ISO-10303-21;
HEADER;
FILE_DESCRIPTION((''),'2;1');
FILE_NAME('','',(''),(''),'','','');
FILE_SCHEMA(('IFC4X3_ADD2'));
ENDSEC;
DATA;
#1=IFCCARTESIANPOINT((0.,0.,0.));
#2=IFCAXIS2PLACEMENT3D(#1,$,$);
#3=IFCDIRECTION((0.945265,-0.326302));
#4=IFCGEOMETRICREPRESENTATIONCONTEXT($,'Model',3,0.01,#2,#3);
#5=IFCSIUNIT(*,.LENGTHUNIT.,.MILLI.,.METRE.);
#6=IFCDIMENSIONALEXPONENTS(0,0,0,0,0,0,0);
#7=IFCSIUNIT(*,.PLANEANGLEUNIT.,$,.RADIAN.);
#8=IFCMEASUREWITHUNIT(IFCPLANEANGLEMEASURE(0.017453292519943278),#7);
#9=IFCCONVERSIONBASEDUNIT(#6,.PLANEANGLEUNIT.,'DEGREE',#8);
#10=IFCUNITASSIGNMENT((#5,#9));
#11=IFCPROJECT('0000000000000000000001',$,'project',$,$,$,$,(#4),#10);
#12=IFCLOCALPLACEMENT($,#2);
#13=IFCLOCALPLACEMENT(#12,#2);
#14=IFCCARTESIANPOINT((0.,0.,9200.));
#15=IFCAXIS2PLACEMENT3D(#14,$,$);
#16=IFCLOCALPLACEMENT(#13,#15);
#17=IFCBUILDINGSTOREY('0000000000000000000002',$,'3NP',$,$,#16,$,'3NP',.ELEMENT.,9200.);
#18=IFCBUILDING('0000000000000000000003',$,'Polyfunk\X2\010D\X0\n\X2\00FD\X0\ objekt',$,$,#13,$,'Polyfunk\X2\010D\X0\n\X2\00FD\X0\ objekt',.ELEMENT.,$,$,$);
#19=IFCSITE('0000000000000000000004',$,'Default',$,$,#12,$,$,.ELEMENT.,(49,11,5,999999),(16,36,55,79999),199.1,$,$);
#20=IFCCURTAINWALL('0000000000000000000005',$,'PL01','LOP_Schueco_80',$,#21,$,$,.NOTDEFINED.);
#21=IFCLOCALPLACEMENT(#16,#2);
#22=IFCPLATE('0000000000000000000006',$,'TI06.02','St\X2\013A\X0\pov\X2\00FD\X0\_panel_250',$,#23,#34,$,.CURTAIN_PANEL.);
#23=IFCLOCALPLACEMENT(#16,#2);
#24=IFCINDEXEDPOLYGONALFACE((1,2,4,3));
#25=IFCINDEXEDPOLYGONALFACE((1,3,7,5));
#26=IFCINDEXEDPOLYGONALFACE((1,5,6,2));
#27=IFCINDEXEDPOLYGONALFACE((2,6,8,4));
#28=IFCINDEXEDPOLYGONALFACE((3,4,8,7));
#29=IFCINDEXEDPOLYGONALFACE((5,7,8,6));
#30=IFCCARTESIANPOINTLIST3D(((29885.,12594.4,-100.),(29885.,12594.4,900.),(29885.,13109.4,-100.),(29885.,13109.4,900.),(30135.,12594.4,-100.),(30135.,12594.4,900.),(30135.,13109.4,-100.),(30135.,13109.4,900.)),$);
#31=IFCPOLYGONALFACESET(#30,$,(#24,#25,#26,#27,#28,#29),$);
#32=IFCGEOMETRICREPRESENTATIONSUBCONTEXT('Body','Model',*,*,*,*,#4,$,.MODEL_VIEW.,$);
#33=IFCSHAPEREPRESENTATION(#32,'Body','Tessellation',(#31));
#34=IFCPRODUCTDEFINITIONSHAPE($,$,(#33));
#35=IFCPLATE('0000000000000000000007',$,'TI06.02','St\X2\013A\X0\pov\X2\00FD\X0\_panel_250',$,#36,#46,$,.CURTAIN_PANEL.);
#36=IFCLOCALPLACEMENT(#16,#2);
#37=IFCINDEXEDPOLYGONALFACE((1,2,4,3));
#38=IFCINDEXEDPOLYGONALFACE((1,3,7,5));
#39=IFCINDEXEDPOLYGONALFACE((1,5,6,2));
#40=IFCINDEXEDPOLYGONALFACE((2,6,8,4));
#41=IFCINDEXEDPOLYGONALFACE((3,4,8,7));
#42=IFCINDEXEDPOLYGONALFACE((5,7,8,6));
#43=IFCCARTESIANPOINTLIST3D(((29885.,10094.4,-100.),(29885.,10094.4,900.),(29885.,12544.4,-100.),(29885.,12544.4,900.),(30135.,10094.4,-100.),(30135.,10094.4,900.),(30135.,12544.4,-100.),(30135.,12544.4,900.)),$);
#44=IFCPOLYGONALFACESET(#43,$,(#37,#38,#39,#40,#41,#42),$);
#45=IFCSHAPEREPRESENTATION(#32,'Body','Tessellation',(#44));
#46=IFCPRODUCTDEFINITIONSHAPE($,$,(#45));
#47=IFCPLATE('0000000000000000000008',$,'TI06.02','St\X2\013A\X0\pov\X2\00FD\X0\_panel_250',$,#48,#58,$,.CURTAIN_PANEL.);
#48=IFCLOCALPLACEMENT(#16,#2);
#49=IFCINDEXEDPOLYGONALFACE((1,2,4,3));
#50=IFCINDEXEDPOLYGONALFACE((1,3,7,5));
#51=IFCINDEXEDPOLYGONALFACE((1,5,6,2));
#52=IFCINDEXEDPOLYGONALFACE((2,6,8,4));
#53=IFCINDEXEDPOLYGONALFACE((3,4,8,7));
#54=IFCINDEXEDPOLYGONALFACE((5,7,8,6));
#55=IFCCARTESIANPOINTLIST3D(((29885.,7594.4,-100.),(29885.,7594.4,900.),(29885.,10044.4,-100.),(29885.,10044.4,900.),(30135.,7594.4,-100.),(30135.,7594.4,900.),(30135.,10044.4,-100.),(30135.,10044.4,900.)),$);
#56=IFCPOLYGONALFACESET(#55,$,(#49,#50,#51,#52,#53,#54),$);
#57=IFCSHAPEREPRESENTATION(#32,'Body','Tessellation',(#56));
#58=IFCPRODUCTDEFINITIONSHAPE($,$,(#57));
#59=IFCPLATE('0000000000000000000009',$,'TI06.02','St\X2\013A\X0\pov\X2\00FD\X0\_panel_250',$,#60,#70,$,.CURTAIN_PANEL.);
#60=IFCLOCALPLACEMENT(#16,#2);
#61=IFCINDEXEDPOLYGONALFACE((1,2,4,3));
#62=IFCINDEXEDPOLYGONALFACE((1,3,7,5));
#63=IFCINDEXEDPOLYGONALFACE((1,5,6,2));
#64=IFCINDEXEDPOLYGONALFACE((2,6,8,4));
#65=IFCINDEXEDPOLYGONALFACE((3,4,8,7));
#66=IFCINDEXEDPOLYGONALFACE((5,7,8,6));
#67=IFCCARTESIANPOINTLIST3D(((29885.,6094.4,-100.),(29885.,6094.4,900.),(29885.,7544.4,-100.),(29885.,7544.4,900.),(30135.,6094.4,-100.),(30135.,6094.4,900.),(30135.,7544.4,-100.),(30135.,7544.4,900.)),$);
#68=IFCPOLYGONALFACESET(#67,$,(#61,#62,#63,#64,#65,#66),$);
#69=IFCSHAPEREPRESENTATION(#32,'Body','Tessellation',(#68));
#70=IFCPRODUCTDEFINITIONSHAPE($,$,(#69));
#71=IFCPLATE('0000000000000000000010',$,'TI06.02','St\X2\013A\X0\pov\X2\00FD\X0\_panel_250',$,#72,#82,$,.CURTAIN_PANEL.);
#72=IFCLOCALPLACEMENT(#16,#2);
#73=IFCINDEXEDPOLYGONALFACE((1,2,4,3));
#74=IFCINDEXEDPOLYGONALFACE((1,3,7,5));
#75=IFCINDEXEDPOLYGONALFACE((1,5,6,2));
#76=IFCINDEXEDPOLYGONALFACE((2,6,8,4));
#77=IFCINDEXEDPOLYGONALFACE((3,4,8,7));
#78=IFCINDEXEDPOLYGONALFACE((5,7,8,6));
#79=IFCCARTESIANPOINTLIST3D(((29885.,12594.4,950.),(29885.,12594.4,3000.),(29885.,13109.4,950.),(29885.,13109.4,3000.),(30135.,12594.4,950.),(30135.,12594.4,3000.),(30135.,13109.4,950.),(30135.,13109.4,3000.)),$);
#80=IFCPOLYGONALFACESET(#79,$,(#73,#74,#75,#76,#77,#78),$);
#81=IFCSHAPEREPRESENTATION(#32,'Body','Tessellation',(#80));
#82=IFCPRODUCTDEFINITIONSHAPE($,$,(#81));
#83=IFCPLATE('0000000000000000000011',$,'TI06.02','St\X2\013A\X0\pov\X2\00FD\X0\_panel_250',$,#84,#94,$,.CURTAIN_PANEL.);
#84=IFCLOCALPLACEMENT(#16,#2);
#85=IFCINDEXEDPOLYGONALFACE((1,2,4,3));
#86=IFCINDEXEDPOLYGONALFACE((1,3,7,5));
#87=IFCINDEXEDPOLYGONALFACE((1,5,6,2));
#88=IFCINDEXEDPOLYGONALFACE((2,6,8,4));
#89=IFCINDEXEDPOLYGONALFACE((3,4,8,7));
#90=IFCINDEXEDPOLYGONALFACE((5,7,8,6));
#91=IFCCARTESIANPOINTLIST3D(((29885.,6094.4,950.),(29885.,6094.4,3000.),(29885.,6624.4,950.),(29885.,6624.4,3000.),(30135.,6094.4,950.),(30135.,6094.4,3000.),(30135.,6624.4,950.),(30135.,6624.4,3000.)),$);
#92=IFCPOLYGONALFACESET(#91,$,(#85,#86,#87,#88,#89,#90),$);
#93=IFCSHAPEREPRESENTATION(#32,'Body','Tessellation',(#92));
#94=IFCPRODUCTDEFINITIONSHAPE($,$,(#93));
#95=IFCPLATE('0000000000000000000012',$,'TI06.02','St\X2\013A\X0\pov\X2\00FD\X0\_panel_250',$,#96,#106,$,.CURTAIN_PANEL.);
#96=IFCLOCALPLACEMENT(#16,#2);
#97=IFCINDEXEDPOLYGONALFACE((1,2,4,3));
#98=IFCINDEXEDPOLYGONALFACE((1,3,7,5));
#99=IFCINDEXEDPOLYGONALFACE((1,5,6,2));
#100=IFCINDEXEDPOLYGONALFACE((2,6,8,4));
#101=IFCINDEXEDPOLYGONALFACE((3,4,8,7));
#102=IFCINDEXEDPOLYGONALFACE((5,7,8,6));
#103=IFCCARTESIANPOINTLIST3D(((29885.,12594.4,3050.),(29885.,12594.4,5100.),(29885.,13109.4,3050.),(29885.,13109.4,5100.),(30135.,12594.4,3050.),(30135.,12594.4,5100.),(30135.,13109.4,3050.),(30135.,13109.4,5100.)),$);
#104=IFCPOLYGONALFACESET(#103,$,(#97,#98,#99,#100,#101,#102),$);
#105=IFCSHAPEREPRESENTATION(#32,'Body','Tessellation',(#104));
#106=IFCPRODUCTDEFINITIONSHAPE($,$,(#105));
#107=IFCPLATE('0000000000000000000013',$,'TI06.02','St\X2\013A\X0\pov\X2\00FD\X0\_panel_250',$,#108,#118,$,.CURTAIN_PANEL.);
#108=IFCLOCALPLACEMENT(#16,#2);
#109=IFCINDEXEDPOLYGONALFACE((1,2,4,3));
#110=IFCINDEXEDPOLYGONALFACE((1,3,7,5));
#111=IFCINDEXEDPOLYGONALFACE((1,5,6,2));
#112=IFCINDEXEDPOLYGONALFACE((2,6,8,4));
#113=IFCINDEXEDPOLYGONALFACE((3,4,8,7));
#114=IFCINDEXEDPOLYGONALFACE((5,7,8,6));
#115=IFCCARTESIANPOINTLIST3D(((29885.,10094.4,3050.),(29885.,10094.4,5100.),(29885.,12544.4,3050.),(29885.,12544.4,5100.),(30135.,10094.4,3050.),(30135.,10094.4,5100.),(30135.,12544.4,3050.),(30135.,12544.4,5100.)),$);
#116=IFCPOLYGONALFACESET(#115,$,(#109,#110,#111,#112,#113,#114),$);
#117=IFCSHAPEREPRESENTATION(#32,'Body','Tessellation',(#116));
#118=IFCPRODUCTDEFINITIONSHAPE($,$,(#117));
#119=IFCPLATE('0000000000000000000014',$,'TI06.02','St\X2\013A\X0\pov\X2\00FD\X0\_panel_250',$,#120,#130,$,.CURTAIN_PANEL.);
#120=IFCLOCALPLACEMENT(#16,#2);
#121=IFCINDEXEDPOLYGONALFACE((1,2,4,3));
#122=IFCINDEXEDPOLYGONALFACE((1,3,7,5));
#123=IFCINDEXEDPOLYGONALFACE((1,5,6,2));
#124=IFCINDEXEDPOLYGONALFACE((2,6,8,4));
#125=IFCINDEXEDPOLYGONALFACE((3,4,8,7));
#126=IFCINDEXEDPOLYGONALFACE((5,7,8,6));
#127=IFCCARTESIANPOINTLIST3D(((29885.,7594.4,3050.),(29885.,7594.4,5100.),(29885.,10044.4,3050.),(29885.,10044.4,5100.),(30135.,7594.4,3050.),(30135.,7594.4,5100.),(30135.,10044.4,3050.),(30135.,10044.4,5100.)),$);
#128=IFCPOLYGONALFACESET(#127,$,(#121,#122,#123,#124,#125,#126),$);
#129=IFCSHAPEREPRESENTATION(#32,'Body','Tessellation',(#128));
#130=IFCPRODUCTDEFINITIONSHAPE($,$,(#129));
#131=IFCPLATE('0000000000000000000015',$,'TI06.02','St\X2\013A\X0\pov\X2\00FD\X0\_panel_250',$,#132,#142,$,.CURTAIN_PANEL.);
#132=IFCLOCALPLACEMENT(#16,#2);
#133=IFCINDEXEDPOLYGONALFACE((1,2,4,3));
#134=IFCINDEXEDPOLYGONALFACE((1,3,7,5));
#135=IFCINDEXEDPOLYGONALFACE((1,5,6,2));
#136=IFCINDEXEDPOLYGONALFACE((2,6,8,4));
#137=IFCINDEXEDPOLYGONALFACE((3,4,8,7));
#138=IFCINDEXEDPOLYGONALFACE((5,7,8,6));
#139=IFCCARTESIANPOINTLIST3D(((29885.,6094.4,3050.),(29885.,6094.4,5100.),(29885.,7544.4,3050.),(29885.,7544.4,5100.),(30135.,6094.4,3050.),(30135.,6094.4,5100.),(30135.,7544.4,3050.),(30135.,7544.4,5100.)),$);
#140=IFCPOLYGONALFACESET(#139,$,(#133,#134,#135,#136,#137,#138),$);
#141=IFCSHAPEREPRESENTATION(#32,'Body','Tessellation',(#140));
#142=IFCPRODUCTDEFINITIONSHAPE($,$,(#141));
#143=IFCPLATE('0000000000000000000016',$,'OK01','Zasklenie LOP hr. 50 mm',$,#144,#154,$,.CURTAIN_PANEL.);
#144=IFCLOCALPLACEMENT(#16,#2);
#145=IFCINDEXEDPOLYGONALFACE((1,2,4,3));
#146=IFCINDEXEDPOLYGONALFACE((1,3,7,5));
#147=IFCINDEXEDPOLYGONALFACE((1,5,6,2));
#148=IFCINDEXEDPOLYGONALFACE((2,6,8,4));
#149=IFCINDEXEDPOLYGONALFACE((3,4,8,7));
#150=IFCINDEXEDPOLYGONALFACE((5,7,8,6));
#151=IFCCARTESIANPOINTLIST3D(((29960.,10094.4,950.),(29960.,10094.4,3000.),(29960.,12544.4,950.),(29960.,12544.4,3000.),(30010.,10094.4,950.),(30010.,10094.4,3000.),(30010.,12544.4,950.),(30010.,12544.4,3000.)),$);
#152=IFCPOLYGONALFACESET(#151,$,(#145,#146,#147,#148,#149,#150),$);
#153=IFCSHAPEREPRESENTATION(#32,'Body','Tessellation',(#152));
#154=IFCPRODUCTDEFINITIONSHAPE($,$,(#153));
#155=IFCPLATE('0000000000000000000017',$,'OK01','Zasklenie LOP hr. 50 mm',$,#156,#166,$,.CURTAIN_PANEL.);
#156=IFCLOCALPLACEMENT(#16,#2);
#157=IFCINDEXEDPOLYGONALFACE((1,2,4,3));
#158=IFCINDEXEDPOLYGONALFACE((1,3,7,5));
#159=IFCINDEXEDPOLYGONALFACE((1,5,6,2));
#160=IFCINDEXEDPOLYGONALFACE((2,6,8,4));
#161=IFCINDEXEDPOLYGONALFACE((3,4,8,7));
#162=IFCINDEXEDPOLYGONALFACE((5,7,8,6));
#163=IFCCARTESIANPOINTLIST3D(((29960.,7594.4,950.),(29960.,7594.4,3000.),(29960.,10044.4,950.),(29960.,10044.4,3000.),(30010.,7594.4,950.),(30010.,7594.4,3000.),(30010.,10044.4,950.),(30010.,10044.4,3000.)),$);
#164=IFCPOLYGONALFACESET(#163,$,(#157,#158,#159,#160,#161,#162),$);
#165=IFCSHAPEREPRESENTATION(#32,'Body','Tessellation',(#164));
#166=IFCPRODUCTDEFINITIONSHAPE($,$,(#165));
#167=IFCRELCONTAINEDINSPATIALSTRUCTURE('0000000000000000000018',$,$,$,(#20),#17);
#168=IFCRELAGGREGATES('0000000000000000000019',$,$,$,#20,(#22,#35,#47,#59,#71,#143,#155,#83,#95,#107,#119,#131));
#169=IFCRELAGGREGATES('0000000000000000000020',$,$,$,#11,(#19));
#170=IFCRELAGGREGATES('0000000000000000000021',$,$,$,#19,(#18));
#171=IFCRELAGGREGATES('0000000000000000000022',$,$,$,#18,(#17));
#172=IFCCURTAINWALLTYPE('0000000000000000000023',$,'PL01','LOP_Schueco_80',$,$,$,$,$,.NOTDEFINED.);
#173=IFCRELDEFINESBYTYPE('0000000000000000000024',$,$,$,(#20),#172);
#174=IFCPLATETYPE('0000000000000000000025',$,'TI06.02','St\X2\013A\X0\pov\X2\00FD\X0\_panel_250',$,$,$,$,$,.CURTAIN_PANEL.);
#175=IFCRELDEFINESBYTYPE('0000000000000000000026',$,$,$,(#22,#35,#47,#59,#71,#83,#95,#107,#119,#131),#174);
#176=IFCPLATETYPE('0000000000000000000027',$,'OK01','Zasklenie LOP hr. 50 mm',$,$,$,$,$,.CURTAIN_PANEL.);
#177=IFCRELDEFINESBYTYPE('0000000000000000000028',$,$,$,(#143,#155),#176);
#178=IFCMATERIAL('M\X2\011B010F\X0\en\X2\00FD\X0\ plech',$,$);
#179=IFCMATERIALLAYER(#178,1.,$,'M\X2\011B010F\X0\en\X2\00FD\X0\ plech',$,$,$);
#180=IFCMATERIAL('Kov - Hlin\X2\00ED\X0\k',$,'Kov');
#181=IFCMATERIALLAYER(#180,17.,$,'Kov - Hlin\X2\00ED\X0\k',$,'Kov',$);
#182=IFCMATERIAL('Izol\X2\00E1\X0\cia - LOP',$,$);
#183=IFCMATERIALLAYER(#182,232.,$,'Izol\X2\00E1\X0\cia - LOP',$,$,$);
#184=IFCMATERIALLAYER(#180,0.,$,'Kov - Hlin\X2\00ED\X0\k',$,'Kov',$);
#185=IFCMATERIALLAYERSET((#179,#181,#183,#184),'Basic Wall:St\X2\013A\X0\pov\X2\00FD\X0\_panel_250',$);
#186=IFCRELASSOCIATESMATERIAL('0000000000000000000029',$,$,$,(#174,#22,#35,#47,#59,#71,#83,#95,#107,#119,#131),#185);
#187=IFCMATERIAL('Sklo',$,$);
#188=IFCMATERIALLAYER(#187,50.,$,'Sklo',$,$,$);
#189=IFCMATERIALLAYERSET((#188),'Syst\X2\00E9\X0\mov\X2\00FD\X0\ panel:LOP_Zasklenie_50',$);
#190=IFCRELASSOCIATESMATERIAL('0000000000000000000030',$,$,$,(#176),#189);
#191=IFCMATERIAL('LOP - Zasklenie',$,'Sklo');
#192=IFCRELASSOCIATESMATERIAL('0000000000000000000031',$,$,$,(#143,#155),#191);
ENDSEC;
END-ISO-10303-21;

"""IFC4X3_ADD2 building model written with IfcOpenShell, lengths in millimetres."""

from ifc_helpers import new_model, entity, si_unit, converted_unit, direction, frame, frame_2d, origin, origin_2d_with_axis, place, context, subcontext, project, spatial, rectangle, extrude, source, transform, mapped, material, layer, layer_set, layer_usage, type_object, element, aggregate, save


model = new_model("IFC4X3_ADD2")

# Units and contexts
model_context = context("Model", 3, precision=0.01, world=origin(), true_north=direction((0.945265, -0.326302)))
body_context = subcontext(model_context, "Body", "Model", "MODEL_VIEW")
ifc_project = project(units=[si_unit("LENGTHUNIT", "METRE", prefix="MILLI"), converted_unit("PLANEANGLEUNIT", "DEGREE", entity("IfcPlaneAngleMeasure", 0.017453292519943278), si_unit("PLANEANGLEUNIT", "RADIAN"), dimensions=[0, 0, 0, 0, 0, 0, 0])], contexts=[model_context])

# Site, building, storey
site_placement = place(None, origin())
site = spatial("IfcSite", under=ifc_project, at=site_placement, Name="Default", CompositionType="ELEMENT", RefLatitude=(49, 11, 5, 999999), RefLongitude=(16, 36, 55, 79999), RefElevation=199.1)
building_placement = place(site_placement, origin())
building = spatial("IfcBuilding", under=site, at=building_placement, Name="Polyfunkčný objekt", LongName="Polyfunkčný objekt", CompositionType="ELEMENT")
storey_placement = place(building_placement, frame((0.0, 0.0, 9200.0)))
storey = spatial("IfcBuildingStorey", under=building, at=storey_placement, Name="3NP", LongName="3NP", CompositionType="ELEMENT", Elevation=9200.0)

# Shared definitions
curtain_wall_type = type_object("IfcCurtainWallType", Name="PL01", Description="LOP_Schueco_80", PredefinedType="NOTDEFINED")

# Curtain wall, plates
curtain_wall_1_placement = place(storey_placement, frame((0.0, 0.0, -9200.0)))
curtain_wall_1 = element("IfcCurtainWall", 1, at=curtain_wall_1_placement, inside=storey, type_object=curtain_wall_type, Name="PL01", Description="LOP_Schueco_80", PredefinedType="NOTDEFINED")
ifc_material_1 = material(Name="Měďený plech")
ifc_layer_1 = layer(ifc_material_1, 1.0, Name="Měďený plech")
ifc_material_2 = material(Name="Kov - Hliník", Category="Kov")
ifc_layer_2 = layer(ifc_material_2, 17.0, Name="Kov - Hliník", Category="Kov")
ifc_material_3 = material(Name="Izolácia - LOP")
ifc_layer_3 = layer(ifc_material_3, 232.0, Name="Izolácia - LOP")
ifc_layer_4 = layer(ifc_material_2, 0.0, Name="Kov - Hliník", Category="Kov")
ifc_layer_set_1 = layer_set([ifc_layer_1, ifc_layer_2, ifc_layer_3, ifc_layer_4], Name="Basic Wall:Stĺpový_panel_250")
ifc_layer_usage_1 = layer_usage(ifc_layer_set_1, "AXIS2", "POSITIVE", -125.0)
plate_type_1 = type_object("IfcPlateType", Name="TI06.02", Description="Stĺpový_panel_250", PredefinedType="CURTAIN_PANEL", material=ifc_layer_set_1)
plate_1_placement = place(storey_placement, frame((30010.0, 13109.4, -100.0), z_axis=(0.0, 0.0, 1.0), x_axis=(0.0, -1.0, 0.0)))
plate_1 = element("IfcPlate", 2, at=plate_1_placement, type_object=plate_type_1, material=ifc_layer_usage_1, Name="TI06.02", Description="Stĺpový_panel_250", PredefinedType="CURTAIN_PANEL", context=body_context, shape_type="SweptSolid", body=[
    extrude(rectangle(XDim=250.0, YDim=515.0, at=frame_2d((0.0, 0.0), x_axis=(1.0, 0.0))), frame((257.5, 0.0, 0.0), z_axis=(0.0, 0.0, 1.0), x_axis=(0.0, 1.0, 0.0)), (0.0, 0.0, 1.0), 1000.0),
])
ifc_layer_usage_2 = layer_usage(ifc_layer_set_1, "AXIS2", "POSITIVE", -125.0)
plate_2_placement = place(storey_placement, frame((30010.0, 12544.4, -100.0), z_axis=(0.0, 0.0, 1.0), x_axis=(0.0, -1.0, 0.0)))
plate_2 = element("IfcPlate", 3, at=plate_2_placement, type_object=plate_type_1, material=ifc_layer_usage_2, Name="TI06.02", Description="Stĺpový_panel_250", PredefinedType="CURTAIN_PANEL", context=body_context, shape_type="SweptSolid", body=[
    extrude(rectangle(XDim=250.0, YDim=2450.0, at=frame_2d((0.0, 0.0), x_axis=(1.0, 0.0))), frame((1225.0, 0.0, 0.0), z_axis=(0.0, 0.0, 1.0), x_axis=(0.0, 1.0, 0.0)), (0.0, 0.0, 1.0), 1000.0),
])
ifc_layer_usage_3 = layer_usage(ifc_layer_set_1, "AXIS2", "POSITIVE", -125.0)
plate_3_placement = place(storey_placement, frame((30010.0, 10044.4, -100.0), z_axis=(0.0, 0.0, 1.0), x_axis=(0.0, -1.0, 0.0)))
plate_3 = element("IfcPlate", 4, at=plate_3_placement, type_object=plate_type_1, material=ifc_layer_usage_3, Name="TI06.02", Description="Stĺpový_panel_250", PredefinedType="CURTAIN_PANEL", context=body_context, shape_type="SweptSolid", body=[
    extrude(rectangle(XDim=250.0, YDim=2450.0, at=origin_2d_with_axis()), frame((1225.0, 0.0, 0.0), z_axis=(0.0, 0.0, 1.0), x_axis=(0.0, 1.0, 0.0)), (0.0, 0.0, 1.0), 1000.0),
])
ifc_layer_usage_4 = layer_usage(ifc_layer_set_1, "AXIS2", "POSITIVE", -125.0)
plate_4_placement = place(storey_placement, frame((30010.0, 7544.4, -100.0), z_axis=(0.0, 0.0, 1.0), x_axis=(0.0, -1.0, 0.0)))
plate_4 = element("IfcPlate", 5, at=plate_4_placement, type_object=plate_type_1, material=ifc_layer_usage_4, Name="TI06.02", Description="Stĺpový_panel_250", PredefinedType="CURTAIN_PANEL", context=body_context, shape_type="SweptSolid", body=[
    extrude(rectangle(XDim=250.0, YDim=1450.0, at=frame_2d((0.0, 0.0), x_axis=(1.0, 0.0))), frame((725.0, 0.0, 0.0), z_axis=(0.0, 0.0, 1.0), x_axis=(0.0, 1.0, 0.0)), (0.0, 0.0, 1.0), 1000.0),
])
ifc_layer_usage_5 = layer_usage(ifc_layer_set_1, "AXIS2", "POSITIVE", -125.0)
plate_5_placement = place(storey_placement, frame((30010.0, 13109.4, 950.0), z_axis=(0.0, 0.0, 1.0), x_axis=(0.0, -1.0, 0.0)))
plate_5 = element("IfcPlate", 6, at=plate_5_placement, type_object=plate_type_1, material=ifc_layer_usage_5, Name="TI06.02", Description="Stĺpový_panel_250", PredefinedType="CURTAIN_PANEL", context=body_context, shape_type="SweptSolid", body=[
    extrude(rectangle(XDim=250.0, YDim=515.0, at=frame_2d((0.0, 0.0), x_axis=(1.0, 0.0))), frame((257.5, 0.0, 0.0), z_axis=(0.0, 0.0, 1.0), x_axis=(0.0, 1.0, 0.0)), (0.0, 0.0, 1.0), 2050.0),
])
ifc_layer_usage_6 = layer_usage(ifc_layer_set_1, "AXIS2", "POSITIVE", -125.0)
plate_6_placement = place(storey_placement, frame((30010.0, 6624.4, 950.0), z_axis=(0.0, 0.0, 1.0), x_axis=(0.0, -1.0, 0.0)))
plate_6 = element("IfcPlate", 7, at=plate_6_placement, type_object=plate_type_1, material=ifc_layer_usage_6, Name="TI06.02", Description="Stĺpový_panel_250", PredefinedType="CURTAIN_PANEL", context=body_context, shape_type="SweptSolid", body=[
    extrude(rectangle(XDim=250.0, YDim=530.0, at=frame_2d((0.0, 0.0), x_axis=(1.0, 0.0))), frame((265.0, 0.0, 0.0), z_axis=(0.0, 0.0, 1.0), x_axis=(0.0, 1.0, 0.0)), (0.0, 0.0, 1.0), 2050.0),
])
ifc_layer_usage_7 = layer_usage(ifc_layer_set_1, "AXIS2", "POSITIVE", -125.0)
plate_7_placement = place(storey_placement, frame((30010.0, 13109.4, 3050.0), z_axis=(0.0, 0.0, 1.0), x_axis=(0.0, -1.0, 0.0)))
plate_7 = element("IfcPlate", 8, at=plate_7_placement, type_object=plate_type_1, material=ifc_layer_usage_7, Name="TI06.02", Description="Stĺpový_panel_250", PredefinedType="CURTAIN_PANEL", context=body_context, shape_type="SweptSolid", body=[
    extrude(rectangle(XDim=250.0, YDim=515.0, at=frame_2d((0.0, 0.0), x_axis=(1.0, 0.0))), frame((257.5, 0.0, 0.0), z_axis=(0.0, 0.0, 1.0), x_axis=(0.0, 1.0, 0.0)), (0.0, 0.0, 1.0), 2050.0),
])
ifc_layer_usage_8 = layer_usage(ifc_layer_set_1, "AXIS2", "POSITIVE", -125.0)
plate_8_placement = place(storey_placement, frame((30010.0, 12544.4, 3050.0), z_axis=(0.0, 0.0, 1.0), x_axis=(0.0, -1.0, 0.0)))
plate_8 = element("IfcPlate", 9, at=plate_8_placement, type_object=plate_type_1, material=ifc_layer_usage_8, Name="TI06.02", Description="Stĺpový_panel_250", PredefinedType="CURTAIN_PANEL", context=body_context, shape_type="SweptSolid", body=[
    extrude(rectangle(XDim=250.0, YDim=2450.0, at=frame_2d((0.0, 0.0), x_axis=(1.0, 0.0))), frame((1225.0, 0.0, 0.0), z_axis=(0.0, 0.0, 1.0), x_axis=(0.0, 1.0, 0.0)), (0.0, 0.0, 1.0), 2050.0),
])
ifc_layer_usage_9 = layer_usage(ifc_layer_set_1, "AXIS2", "POSITIVE", -125.0)
plate_9_placement = place(storey_placement, frame((30010.0, 10044.4, 3050.0), z_axis=(0.0, 0.0, 1.0), x_axis=(0.0, -1.0, 0.0)))
plate_9 = element("IfcPlate", 10, at=plate_9_placement, type_object=plate_type_1, material=ifc_layer_usage_9, Name="TI06.02", Description="Stĺpový_panel_250", PredefinedType="CURTAIN_PANEL", context=body_context, shape_type="SweptSolid", body=[
    extrude(rectangle(XDim=250.0, YDim=2450.0, at=frame_2d((0.0, 0.0), x_axis=(1.0, 0.0))), frame((1225.0, 0.0, 0.0), z_axis=(0.0, 0.0, 1.0), x_axis=(0.0, 1.0, 0.0)), (0.0, 0.0, 1.0), 2050.0),
])
ifc_layer_usage_10 = layer_usage(ifc_layer_set_1, "AXIS2", "POSITIVE", -125.0)
plate_10_placement = place(storey_placement, frame((30010.0, 7544.4, 3050.0), z_axis=(0.0, 0.0, 1.0), x_axis=(0.0, -1.0, 0.0)))
plate_10 = element("IfcPlate", 11, at=plate_10_placement, type_object=plate_type_1, material=ifc_layer_usage_10, Name="TI06.02", Description="Stĺpový_panel_250", PredefinedType="CURTAIN_PANEL", context=body_context, shape_type="SweptSolid", body=[
    extrude(rectangle(XDim=250.0, YDim=1450.0, at=frame_2d((0.0, 0.0), x_axis=(1.0, 0.0))), frame((725.0, 0.0, 0.0), z_axis=(0.0, 0.0, 1.0), x_axis=(0.0, 1.0, 0.0)), (0.0, 0.0, 1.0), 2050.0),
])
ifc_material_4 = material(Name="LOP - Zasklenie", Category="Sklo")
ifc_material_5 = material(Name="Sklo")
ifc_layer_5 = layer(ifc_material_5, 50.0, Name="Sklo")
ifc_layer_set_2 = layer_set([ifc_layer_5], Name="Systémový panel:LOP_Zasklenie_50")
plate_type_2 = type_object("IfcPlateType", Name="OK01", Description="Zasklenie LOP hr. 50 mm", PredefinedType="CURTAIN_PANEL", material=ifc_layer_set_2)
shared_shape_1 = source(origin(), body_context, "Body", "SweptSolid", [
    extrude(rectangle(XDim=50.0, YDim=2450.0, at=origin_2d_with_axis()), frame((0.0, -25.0, 0.0), z_axis=(0.0, 0.0, 1.0), x_axis=(0.0, 1.0, 0.0)), (0.0, 0.0, 1.0), 2050.0),
])
plate_11_placement = place(curtain_wall_1_placement, frame((30010.0, 11319.4, 10150.0), z_axis=(0.0, 0.0, 1.0), x_axis=(0.0, -1.0, 0.0)))
plate_11 = element("IfcPlate", 12, at=plate_11_placement, type_object=plate_type_2, material=ifc_material_4, Name="OK01", Description="Zasklenie LOP hr. 50 mm", PredefinedType="CURTAIN_PANEL", context=body_context, shape_type="MappedRepresentation", body=[
    mapped(shared_shape_1, transform((0.0, 0.0, 0.0), scale=1.0)),
])
plate_12_placement = place(curtain_wall_1_placement, frame((30010.0, 8819.4, 10150.0), z_axis=(0.0, 0.0, 1.0), x_axis=(0.0, -1.0, 0.0)))
plate_12 = element("IfcPlate", 13, at=plate_12_placement, type_object=plate_type_2, material=ifc_material_4, Name="OK01", Description="Zasklenie LOP hr. 50 mm", PredefinedType="CURTAIN_PANEL", context=body_context, shape_type="MappedRepresentation", body=[
    mapped(shared_shape_1, transform((0.0, 0.0, 0.0), scale=1.0)),
])
aggregate(curtain_wall_1, [plate_1, plate_2, plate_3, plate_4, plate_5, plate_11, plate_12, plate_6, plate_7, plate_8, plate_9, plate_10])

save(model, "model.ifc")
